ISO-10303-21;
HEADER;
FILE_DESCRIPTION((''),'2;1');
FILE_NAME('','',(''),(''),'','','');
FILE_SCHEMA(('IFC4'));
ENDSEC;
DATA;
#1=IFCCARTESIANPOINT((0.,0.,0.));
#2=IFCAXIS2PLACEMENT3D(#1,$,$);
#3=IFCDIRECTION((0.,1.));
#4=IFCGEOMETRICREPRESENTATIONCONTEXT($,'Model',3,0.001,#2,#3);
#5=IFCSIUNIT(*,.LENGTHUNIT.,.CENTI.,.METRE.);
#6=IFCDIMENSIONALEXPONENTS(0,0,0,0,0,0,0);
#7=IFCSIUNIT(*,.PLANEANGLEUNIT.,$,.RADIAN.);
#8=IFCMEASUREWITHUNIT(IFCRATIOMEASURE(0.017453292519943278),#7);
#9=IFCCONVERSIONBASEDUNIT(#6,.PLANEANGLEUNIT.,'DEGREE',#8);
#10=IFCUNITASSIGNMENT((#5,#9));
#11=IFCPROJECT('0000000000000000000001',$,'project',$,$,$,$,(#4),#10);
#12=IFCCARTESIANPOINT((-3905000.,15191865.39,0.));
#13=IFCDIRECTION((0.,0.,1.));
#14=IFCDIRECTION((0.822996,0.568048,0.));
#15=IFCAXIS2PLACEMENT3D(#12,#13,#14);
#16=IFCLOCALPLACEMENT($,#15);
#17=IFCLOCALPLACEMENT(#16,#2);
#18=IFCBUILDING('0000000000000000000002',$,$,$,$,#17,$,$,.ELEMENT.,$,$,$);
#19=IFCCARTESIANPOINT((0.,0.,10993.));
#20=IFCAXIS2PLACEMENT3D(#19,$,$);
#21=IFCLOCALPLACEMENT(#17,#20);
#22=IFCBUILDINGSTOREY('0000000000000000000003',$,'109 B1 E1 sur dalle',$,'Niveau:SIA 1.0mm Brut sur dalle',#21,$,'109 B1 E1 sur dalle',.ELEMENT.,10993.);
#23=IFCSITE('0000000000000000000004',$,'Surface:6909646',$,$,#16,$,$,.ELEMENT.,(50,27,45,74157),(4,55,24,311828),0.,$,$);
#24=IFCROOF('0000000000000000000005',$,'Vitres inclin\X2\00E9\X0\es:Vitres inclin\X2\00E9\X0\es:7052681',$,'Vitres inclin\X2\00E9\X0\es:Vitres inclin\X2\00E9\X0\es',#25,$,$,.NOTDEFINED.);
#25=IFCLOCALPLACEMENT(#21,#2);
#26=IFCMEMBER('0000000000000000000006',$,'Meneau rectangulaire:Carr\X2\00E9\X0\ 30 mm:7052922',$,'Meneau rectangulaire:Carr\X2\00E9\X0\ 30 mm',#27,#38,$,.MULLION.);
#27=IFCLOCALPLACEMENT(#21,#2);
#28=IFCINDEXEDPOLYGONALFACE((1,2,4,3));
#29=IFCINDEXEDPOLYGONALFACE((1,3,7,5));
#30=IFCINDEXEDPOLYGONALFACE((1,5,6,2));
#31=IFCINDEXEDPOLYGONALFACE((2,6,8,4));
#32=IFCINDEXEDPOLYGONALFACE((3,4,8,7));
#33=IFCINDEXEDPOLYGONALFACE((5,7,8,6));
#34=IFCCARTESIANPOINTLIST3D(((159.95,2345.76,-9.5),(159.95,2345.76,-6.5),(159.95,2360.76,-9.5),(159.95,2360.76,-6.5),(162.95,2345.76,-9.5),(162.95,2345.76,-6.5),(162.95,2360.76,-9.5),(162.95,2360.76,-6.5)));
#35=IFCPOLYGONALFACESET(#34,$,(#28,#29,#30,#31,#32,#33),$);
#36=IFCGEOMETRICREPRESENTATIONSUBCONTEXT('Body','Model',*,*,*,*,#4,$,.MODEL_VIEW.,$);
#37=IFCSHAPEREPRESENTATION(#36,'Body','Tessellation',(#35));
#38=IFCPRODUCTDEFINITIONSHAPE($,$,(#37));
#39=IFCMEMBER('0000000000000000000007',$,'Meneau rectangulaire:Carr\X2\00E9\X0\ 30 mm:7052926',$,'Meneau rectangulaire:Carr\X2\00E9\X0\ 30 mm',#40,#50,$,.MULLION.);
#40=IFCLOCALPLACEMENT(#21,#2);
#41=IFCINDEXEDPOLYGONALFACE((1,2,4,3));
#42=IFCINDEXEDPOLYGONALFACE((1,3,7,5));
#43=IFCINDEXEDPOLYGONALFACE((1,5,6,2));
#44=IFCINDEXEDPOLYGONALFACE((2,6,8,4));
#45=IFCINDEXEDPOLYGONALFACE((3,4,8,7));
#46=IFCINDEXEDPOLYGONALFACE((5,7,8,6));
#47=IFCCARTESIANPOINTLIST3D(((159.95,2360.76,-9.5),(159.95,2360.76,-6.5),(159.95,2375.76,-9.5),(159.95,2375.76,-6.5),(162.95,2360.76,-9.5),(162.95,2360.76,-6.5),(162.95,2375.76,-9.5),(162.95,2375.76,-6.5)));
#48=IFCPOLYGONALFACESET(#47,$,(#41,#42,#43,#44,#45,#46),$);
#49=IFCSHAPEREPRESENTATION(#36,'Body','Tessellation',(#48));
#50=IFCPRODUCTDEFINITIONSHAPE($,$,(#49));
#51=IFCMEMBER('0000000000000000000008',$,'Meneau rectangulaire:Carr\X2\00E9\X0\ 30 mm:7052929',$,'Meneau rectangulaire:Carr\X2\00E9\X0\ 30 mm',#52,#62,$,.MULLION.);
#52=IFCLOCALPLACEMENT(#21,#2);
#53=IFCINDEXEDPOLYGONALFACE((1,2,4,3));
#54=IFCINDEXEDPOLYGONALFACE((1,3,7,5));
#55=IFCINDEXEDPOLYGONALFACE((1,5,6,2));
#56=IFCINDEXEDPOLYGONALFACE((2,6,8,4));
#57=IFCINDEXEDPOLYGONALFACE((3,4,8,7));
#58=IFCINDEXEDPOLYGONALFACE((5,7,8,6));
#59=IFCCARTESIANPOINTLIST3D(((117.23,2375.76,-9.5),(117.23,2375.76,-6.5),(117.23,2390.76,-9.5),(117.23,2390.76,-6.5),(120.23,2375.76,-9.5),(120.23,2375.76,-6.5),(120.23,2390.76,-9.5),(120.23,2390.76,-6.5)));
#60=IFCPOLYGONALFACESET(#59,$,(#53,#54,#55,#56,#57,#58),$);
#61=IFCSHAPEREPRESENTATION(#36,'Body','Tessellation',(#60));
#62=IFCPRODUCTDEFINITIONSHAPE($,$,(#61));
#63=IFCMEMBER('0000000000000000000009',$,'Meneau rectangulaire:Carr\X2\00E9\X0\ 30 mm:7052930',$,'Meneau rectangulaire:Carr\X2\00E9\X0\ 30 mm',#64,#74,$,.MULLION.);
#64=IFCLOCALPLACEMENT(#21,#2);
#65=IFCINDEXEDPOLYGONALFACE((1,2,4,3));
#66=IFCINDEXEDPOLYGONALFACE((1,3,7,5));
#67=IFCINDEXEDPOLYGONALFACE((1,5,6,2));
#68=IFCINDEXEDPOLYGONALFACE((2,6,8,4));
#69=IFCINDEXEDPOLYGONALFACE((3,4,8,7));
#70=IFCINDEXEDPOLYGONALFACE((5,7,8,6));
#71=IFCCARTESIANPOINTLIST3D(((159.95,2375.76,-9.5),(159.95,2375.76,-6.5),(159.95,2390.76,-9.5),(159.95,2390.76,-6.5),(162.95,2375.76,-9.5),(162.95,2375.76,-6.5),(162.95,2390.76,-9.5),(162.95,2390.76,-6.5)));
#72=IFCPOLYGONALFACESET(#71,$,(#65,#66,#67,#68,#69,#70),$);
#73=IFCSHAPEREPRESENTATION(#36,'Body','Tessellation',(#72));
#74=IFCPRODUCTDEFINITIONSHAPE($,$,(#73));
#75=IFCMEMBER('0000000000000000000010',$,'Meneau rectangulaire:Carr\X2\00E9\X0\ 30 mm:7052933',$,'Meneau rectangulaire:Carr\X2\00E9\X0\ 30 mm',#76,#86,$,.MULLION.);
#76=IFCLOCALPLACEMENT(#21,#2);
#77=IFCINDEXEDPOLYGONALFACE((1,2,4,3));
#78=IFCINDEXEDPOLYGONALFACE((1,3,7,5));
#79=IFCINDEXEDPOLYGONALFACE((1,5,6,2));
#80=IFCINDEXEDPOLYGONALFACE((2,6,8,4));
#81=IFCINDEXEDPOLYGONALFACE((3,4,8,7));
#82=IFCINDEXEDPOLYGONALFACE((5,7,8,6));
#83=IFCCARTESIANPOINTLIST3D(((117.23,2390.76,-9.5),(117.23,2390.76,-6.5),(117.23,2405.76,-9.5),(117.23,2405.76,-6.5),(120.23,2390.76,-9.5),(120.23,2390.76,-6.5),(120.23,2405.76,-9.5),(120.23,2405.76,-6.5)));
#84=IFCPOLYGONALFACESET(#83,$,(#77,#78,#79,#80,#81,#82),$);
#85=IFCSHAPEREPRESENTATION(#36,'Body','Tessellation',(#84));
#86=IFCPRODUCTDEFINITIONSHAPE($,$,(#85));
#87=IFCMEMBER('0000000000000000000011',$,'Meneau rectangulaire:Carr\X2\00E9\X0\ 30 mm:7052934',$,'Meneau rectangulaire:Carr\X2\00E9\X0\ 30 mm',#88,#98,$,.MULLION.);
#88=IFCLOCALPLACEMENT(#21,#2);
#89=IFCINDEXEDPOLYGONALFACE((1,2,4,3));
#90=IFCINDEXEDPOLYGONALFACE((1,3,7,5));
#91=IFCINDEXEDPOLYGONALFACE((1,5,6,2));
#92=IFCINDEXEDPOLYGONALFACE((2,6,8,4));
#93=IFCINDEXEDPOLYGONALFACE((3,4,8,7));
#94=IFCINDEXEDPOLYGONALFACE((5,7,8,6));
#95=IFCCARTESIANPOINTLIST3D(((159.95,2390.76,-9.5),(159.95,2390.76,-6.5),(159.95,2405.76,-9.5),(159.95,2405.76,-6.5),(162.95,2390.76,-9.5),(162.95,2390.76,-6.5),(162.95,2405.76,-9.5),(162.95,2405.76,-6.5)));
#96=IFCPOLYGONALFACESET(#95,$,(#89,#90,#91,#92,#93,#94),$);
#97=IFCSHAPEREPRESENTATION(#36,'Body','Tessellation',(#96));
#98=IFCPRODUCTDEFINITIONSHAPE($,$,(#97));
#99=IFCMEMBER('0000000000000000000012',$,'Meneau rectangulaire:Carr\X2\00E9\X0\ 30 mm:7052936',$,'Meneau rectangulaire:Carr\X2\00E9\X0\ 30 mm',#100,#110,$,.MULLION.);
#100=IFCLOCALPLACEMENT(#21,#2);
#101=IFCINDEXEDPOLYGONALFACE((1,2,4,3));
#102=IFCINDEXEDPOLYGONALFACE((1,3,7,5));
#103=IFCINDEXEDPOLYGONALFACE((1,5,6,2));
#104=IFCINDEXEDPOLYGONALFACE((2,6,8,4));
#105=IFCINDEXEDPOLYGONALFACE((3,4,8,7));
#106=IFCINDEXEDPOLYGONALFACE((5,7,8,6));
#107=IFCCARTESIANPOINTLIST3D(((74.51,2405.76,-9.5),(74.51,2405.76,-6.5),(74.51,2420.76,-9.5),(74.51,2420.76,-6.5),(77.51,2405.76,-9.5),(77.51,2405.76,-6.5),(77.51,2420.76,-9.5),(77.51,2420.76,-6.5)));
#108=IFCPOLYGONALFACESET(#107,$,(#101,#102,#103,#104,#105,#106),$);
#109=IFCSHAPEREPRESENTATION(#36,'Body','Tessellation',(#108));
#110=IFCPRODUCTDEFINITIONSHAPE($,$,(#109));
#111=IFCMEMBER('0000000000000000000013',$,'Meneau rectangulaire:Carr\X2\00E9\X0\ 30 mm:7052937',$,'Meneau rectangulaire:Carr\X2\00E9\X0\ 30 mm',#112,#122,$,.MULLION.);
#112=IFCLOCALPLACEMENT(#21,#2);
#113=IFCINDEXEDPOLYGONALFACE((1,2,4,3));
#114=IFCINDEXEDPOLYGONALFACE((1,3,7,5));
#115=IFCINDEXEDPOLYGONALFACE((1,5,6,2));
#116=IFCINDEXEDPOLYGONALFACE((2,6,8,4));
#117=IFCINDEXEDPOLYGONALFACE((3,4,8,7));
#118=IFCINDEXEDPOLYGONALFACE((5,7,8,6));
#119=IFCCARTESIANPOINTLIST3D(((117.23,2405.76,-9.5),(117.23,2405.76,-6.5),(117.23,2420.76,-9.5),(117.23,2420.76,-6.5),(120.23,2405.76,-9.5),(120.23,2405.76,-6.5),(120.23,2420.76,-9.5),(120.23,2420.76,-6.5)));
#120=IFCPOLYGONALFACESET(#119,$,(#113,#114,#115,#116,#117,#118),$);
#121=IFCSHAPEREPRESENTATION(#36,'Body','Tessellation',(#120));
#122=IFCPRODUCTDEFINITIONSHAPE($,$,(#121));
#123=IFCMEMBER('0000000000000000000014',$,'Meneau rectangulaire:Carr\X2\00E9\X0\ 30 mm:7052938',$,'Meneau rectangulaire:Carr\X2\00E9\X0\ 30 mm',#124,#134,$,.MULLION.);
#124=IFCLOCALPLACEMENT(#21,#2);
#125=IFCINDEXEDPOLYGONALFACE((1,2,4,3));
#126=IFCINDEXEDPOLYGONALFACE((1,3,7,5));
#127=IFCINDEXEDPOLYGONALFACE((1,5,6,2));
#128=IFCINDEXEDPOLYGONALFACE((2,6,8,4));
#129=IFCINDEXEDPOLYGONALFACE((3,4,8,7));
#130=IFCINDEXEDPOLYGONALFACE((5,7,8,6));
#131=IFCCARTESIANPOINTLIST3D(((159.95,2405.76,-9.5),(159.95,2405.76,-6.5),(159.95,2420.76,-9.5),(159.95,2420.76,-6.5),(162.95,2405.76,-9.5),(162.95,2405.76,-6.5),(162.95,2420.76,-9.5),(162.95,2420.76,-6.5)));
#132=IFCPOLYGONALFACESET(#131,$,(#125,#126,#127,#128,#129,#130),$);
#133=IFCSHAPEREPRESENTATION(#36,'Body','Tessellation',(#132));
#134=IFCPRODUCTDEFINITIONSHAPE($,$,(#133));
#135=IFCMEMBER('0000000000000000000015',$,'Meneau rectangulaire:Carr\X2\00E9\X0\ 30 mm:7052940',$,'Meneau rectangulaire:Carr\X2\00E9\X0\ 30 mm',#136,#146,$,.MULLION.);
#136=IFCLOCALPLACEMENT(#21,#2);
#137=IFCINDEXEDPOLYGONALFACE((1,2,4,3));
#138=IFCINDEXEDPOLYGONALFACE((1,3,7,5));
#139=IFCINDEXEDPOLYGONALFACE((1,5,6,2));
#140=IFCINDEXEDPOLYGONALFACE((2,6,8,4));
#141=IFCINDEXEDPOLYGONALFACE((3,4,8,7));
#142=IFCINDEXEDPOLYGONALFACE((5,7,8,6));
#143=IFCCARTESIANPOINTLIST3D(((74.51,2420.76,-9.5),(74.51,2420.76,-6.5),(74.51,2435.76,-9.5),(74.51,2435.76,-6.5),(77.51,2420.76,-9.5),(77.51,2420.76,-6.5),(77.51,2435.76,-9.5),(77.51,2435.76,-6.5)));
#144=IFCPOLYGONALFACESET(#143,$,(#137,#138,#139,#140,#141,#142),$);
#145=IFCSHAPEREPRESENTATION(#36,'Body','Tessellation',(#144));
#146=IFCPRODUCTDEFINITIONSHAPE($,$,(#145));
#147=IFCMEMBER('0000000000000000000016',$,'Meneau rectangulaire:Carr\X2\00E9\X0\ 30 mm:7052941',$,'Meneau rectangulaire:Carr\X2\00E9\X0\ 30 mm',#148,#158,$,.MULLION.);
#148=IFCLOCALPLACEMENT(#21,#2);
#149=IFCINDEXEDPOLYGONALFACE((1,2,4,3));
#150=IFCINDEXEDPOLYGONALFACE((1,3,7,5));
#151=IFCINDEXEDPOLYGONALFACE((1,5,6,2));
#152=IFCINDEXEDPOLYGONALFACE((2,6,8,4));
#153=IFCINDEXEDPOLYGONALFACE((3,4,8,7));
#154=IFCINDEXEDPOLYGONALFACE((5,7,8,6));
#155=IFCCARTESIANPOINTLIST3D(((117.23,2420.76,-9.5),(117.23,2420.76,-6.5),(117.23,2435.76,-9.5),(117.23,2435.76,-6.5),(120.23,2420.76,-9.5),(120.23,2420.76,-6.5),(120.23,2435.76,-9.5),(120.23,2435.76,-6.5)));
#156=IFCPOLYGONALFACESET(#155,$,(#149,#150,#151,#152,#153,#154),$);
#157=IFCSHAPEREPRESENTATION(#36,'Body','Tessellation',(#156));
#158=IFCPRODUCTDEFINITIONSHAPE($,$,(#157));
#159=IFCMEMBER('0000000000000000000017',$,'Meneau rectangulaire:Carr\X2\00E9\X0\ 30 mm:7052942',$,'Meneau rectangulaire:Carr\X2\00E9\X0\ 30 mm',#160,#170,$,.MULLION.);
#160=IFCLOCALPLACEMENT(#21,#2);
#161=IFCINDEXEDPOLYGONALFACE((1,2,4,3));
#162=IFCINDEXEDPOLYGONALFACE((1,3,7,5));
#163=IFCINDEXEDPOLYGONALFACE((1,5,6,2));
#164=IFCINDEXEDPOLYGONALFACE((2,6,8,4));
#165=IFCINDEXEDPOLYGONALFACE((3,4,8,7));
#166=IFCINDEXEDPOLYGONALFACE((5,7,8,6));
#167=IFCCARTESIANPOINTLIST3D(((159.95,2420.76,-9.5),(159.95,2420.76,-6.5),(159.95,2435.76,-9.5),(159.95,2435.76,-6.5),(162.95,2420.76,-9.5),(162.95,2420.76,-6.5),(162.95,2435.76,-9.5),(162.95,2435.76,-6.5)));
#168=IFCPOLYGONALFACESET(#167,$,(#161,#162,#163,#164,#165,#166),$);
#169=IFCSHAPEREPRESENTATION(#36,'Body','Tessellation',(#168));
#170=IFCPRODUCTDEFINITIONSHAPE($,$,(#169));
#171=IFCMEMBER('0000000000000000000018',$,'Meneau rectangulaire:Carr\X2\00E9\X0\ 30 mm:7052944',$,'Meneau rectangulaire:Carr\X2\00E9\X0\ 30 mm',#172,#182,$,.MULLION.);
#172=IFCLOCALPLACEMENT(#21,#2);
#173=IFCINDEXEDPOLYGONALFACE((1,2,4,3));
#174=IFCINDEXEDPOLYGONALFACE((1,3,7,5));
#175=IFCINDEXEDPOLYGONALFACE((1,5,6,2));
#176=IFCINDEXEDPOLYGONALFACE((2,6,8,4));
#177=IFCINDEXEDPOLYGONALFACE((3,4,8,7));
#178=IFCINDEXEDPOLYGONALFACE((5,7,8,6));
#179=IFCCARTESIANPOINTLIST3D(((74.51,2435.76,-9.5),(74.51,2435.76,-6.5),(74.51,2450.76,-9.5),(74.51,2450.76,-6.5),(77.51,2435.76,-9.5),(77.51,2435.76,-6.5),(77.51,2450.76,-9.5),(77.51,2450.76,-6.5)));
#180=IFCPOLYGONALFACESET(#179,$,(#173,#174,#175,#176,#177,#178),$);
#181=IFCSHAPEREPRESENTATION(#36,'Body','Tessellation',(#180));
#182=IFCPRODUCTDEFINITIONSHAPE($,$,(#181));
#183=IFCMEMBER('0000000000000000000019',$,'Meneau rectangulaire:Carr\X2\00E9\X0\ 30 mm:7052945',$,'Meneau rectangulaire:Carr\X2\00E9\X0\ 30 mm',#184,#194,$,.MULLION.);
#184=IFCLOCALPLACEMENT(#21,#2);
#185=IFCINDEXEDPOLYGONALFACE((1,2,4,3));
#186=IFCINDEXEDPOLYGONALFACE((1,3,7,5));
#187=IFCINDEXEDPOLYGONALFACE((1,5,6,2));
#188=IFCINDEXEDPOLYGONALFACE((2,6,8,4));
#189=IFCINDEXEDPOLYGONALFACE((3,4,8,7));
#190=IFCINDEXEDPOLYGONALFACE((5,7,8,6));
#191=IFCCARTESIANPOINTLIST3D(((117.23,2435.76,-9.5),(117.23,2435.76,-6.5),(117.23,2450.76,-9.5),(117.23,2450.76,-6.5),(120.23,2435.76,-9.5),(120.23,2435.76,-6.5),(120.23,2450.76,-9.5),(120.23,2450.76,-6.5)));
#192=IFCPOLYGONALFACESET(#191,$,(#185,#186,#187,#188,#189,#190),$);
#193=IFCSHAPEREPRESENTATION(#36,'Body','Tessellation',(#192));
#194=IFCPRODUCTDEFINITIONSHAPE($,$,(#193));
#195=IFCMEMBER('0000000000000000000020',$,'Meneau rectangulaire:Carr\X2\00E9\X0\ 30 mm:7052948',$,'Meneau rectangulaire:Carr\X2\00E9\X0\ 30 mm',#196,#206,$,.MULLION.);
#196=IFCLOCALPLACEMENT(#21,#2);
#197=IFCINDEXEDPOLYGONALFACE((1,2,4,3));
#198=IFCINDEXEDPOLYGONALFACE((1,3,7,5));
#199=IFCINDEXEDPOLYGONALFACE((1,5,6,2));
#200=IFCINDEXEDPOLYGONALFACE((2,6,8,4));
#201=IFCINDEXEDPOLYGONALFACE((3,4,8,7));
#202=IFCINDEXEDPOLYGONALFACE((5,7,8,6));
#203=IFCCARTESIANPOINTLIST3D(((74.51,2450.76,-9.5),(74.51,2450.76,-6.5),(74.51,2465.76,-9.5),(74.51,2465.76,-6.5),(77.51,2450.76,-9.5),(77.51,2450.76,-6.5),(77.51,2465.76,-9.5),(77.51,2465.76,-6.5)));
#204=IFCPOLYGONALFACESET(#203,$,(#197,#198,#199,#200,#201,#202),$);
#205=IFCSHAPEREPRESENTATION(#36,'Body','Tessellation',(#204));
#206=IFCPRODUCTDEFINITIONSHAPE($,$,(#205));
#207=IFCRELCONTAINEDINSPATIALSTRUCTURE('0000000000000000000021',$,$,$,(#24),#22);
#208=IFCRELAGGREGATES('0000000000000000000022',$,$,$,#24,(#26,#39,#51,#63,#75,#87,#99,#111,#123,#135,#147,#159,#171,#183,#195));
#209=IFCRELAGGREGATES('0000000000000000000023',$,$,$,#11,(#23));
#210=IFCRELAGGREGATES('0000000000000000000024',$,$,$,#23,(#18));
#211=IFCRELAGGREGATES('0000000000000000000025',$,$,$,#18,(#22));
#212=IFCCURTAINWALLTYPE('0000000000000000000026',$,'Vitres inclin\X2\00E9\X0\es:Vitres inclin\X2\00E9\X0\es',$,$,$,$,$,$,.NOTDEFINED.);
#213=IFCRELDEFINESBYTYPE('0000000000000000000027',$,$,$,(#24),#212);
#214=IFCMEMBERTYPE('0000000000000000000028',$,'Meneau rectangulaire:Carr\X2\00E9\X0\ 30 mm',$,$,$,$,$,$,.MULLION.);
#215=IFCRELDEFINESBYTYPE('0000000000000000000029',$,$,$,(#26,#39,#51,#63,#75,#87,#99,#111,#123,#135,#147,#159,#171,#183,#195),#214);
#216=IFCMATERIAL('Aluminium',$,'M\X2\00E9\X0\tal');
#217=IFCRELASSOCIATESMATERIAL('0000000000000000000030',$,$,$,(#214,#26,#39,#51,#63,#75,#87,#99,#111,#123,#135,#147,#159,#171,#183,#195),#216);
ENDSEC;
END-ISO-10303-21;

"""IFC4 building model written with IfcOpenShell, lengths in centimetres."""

from ifc_helpers import new_model, entity, si_unit, converted_unit, direction, frame, origin, place, context, subcontext, project, spatial, indexed_curve, outline, extrude, source, transform, mapped, material, type_object, type_shapes, element, aggregate, save


model = new_model("IFC4")

# Units and contexts
model_context = context("Model", 3, precision=0.001, world=origin(), true_north=direction((0.0, 1.0)))
body_context = subcontext(model_context, "Body", "Model", "MODEL_VIEW")
ifc_project = project(units=[si_unit("LENGTHUNIT", "METRE", prefix="CENTI"), converted_unit("PLANEANGLEUNIT", "DEGREE", entity("IfcRatioMeasure", 0.017453292519943278), si_unit("PLANEANGLEUNIT", "RADIAN"), dimensions=[0, 0, 0, 0, 0, 0, 0])], contexts=[model_context])

# Site, building, storey
site_placement = place(None, frame((-3905000.0, 15191865.39, 0.0), z_axis=(0.0, 0.0, 1.0), x_axis=(0.822996, 0.568048, 0.0)))
site = spatial("IfcSite", under=ifc_project, at=site_placement, Name="Surface:6909646", CompositionType="ELEMENT", RefLatitude=(50, 27, 45, 74157), RefLongitude=(4, 55, 24, 311828), RefElevation=0.0)
building_placement = place(site_placement, origin())
building = spatial("IfcBuilding", under=site, at=building_placement, CompositionType="ELEMENT")
storey_placement = place(building_placement, frame((0.0, 0.0, 10993.0)))
storey = spatial("IfcBuildingStorey", under=building, at=storey_placement, Name="109 B1 E1 sur dalle", ObjectType="Niveau:SIA 1.0mm Brut sur dalle", LongName="109 B1 E1 sur dalle", CompositionType="ELEMENT", Elevation=10993.0)

# Roof, members
curtain_wall_type = type_object("IfcCurtainWallType", Name="Vitres inclinées:Vitres inclinées", PredefinedType="NOTDEFINED")
roof_placement = place(storey_placement, frame((0.0, 0.0, -10993.0)))
roof = element("IfcRoof", 1, at=roof_placement, inside=storey, type_object=curtain_wall_type, Name="Vitres inclinées:Vitres inclinées:7052681", ObjectType="Vitres inclinées:Vitres inclinées", PredefinedType="NOTDEFINED")
ifc_material = material(Name="Aluminium", Category="Métal")
member_type_1 = type_object("IfcMemberType", Name="Meneau rectangulaire:Carré 30 mm", PredefinedType="MULLION", material=ifc_material)
shared_shape_1 = source(origin(), body_context, "Body", "SweptSolid", [
    extrude(outline(indexed_curve([(-1.5, -1.5), (1.5, -1.5), (1.5, 1.5), (-1.5, 1.5), (-1.5, -1.5)], self_intersect=False)), frame((0.0, 0.0, -15.0), z_axis=(0.0, 0.0, 1.0), x_axis=(0.0, -1.0, 0.0)), (0.0, 0.0, 1.0), 15.0),
])
type_shapes(member_type_1, [shared_shape_1])
member_1_placement = place(roof_placement, frame((161.45, 2360.76, 10985.0), z_axis=(0.0, 1.0, 0.0), x_axis=(1.0, 0.0, 0.0)))
member_1 = element("IfcMember", 2, at=member_1_placement, type_object=member_type_1, material=ifc_material, Name="Meneau rectangulaire:Carré 30 mm:7052922", ObjectType="Meneau rectangulaire:Carré 30 mm", PredefinedType="MULLION", context=body_context, shape_type="MappedRepresentation", body=[
    mapped(shared_shape_1, transform((0.0, 0.0, 0.0), scale=1.0)),
])
member_2_placement = place(roof_placement, frame((161.45, 2375.76, 10985.0), z_axis=(0.0, 1.0, 0.0), x_axis=(1.0, 0.0, 0.0)))
member_2 = element("IfcMember", 3, at=member_2_placement, type_object=member_type_1, material=ifc_material, Name="Meneau rectangulaire:Carré 30 mm:7052926", ObjectType="Meneau rectangulaire:Carré 30 mm", PredefinedType="MULLION", context=body_context, shape_type="MappedRepresentation", body=[
    mapped(shared_shape_1, transform((0.0, 0.0, 0.0), scale=1.0)),
])
member_3_placement = place(roof_placement, frame((118.73, 2390.76, 10985.0), z_axis=(0.0, 1.0, 0.0), x_axis=(1.0, 0.0, 0.0)))
member_3 = element("IfcMember", 4, at=member_3_placement, type_object=member_type_1, material=ifc_material, Name="Meneau rectangulaire:Carré 30 mm:7052929", ObjectType="Meneau rectangulaire:Carré 30 mm", PredefinedType="MULLION", context=body_context, shape_type="MappedRepresentation", body=[
    mapped(shared_shape_1, transform((0.0, 0.0, 0.0), scale=1.0)),
])
member_4_placement = place(roof_placement, frame((161.45, 2390.76, 10985.0), z_axis=(0.0, 1.0, 0.0), x_axis=(1.0, 0.0, 0.0)))
member_4 = element("IfcMember", 5, at=member_4_placement, type_object=member_type_1, material=ifc_material, Name="Meneau rectangulaire:Carré 30 mm:7052930", ObjectType="Meneau rectangulaire:Carré 30 mm", PredefinedType="MULLION", context=body_context, shape_type="MappedRepresentation", body=[
    mapped(shared_shape_1, transform((0.0, 0.0, 0.0), scale=1.0)),
])
member_5_placement = place(roof_placement, frame((118.73, 2405.76, 10985.0), z_axis=(0.0, 1.0, 0.0), x_axis=(1.0, 0.0, 0.0)))
member_5 = element("IfcMember", 6, at=member_5_placement, type_object=member_type_1, material=ifc_material, Name="Meneau rectangulaire:Carré 30 mm:7052933", ObjectType="Meneau rectangulaire:Carré 30 mm", PredefinedType="MULLION", context=body_context, shape_type="MappedRepresentation", body=[
    mapped(shared_shape_1, transform((0.0, 0.0, 0.0), scale=1.0)),
])
member_6_placement = place(roof_placement, frame((161.45, 2405.76, 10985.0), z_axis=(0.0, 1.0, 0.0), x_axis=(1.0, 0.0, 0.0)))
member_6 = element("IfcMember", 7, at=member_6_placement, type_object=member_type_1, material=ifc_material, Name="Meneau rectangulaire:Carré 30 mm:7052934", ObjectType="Meneau rectangulaire:Carré 30 mm", PredefinedType="MULLION", context=body_context, shape_type="MappedRepresentation", body=[
    mapped(shared_shape_1, transform((0.0, 0.0, 0.0), scale=1.0)),
])
member_7_placement = place(roof_placement, frame((76.01, 2420.76, 10985.0), z_axis=(0.0, 1.0, 0.0), x_axis=(1.0, 0.0, 0.0)))
member_7 = element("IfcMember", 8, at=member_7_placement, type_object=member_type_1, material=ifc_material, Name="Meneau rectangulaire:Carré 30 mm:7052936", ObjectType="Meneau rectangulaire:Carré 30 mm", PredefinedType="MULLION", context=body_context, shape_type="MappedRepresentation", body=[
    mapped(shared_shape_1, transform((0.0, 0.0, 0.0), scale=1.0)),
])
member_8_placement = place(roof_placement, frame((118.73, 2420.76, 10985.0), z_axis=(0.0, 1.0, 0.0), x_axis=(1.0, 0.0, 0.0)))
member_8 = element("IfcMember", 9, at=member_8_placement, type_object=member_type_1, material=ifc_material, Name="Meneau rectangulaire:Carré 30 mm:7052937", ObjectType="Meneau rectangulaire:Carré 30 mm", PredefinedType="MULLION", context=body_context, shape_type="MappedRepresentation", body=[
    mapped(shared_shape_1, transform((0.0, 0.0, 0.0), scale=1.0)),
])
member_9_placement = place(roof_placement, frame((161.45, 2420.76, 10985.0), z_axis=(0.0, 1.0, 0.0), x_axis=(1.0, 0.0, 0.0)))
member_9 = element("IfcMember", 10, at=member_9_placement, type_object=member_type_1, material=ifc_material, Name="Meneau rectangulaire:Carré 30 mm:7052938", ObjectType="Meneau rectangulaire:Carré 30 mm", PredefinedType="MULLION", context=body_context, shape_type="MappedRepresentation", body=[
    mapped(shared_shape_1, transform((0.0, 0.0, 0.0), scale=1.0)),
])
member_10_placement = place(roof_placement, frame((76.01, 2435.76, 10985.0), z_axis=(0.0, 1.0, 0.0), x_axis=(1.0, 0.0, 0.0)))
member_10 = element("IfcMember", 11, at=member_10_placement, type_object=member_type_1, material=ifc_material, Name="Meneau rectangulaire:Carré 30 mm:7052940", ObjectType="Meneau rectangulaire:Carré 30 mm", PredefinedType="MULLION", context=body_context, shape_type="MappedRepresentation", body=[
    mapped(shared_shape_1, transform((0.0, 0.0, 0.0), scale=1.0)),
])
member_11_placement = place(roof_placement, frame((118.73, 2435.76, 10985.0), z_axis=(0.0, 1.0, 0.0), x_axis=(1.0, 0.0, 0.0)))
member_11 = element("IfcMember", 12, at=member_11_placement, type_object=member_type_1, material=ifc_material, Name="Meneau rectangulaire:Carré 30 mm:7052941", ObjectType="Meneau rectangulaire:Carré 30 mm", PredefinedType="MULLION", context=body_context, shape_type="MappedRepresentation", body=[
    mapped(shared_shape_1, transform((0.0, 0.0, 0.0), scale=1.0)),
])
member_12_placement = place(roof_placement, frame((161.45, 2435.76, 10985.0), z_axis=(0.0, 1.0, 0.0), x_axis=(1.0, 0.0, 0.0)))
member_12 = element("IfcMember", 13, at=member_12_placement, type_object=member_type_1, material=ifc_material, Name="Meneau rectangulaire:Carré 30 mm:7052942", ObjectType="Meneau rectangulaire:Carré 30 mm", PredefinedType="MULLION", context=body_context, shape_type="MappedRepresentation", body=[
    mapped(shared_shape_1, transform((0.0, 0.0, 0.0), scale=1.0)),
])
member_13_placement = place(roof_placement, frame((76.01, 2450.76, 10985.0), z_axis=(0.0, 1.0, 0.0), x_axis=(1.0, 0.0, 0.0)))
member_13 = element("IfcMember", 14, at=member_13_placement, type_object=member_type_1, material=ifc_material, Name="Meneau rectangulaire:Carré 30 mm:7052944", ObjectType="Meneau rectangulaire:Carré 30 mm", PredefinedType="MULLION", context=body_context, shape_type="MappedRepresentation", body=[
    mapped(shared_shape_1, transform((0.0, 0.0, 0.0), scale=1.0)),
])
member_14_placement = place(roof_placement, frame((118.73, 2450.76, 10985.0), z_axis=(0.0, 1.0, 0.0), x_axis=(1.0, 0.0, 0.0)))
member_14 = element("IfcMember", 15, at=member_14_placement, type_object=member_type_1, material=ifc_material, Name="Meneau rectangulaire:Carré 30 mm:7052945", ObjectType="Meneau rectangulaire:Carré 30 mm", PredefinedType="MULLION", context=body_context, shape_type="MappedRepresentation", body=[
    mapped(shared_shape_1, transform((0.0, 0.0, 0.0), scale=1.0)),
])
member_15_placement = place(roof_placement, frame((76.01, 2465.76, 10985.0), z_axis=(0.0, 1.0, 0.0), x_axis=(1.0, 0.0, 0.0)))
member_15 = element("IfcMember", 16, at=member_15_placement, type_object=member_type_1, material=ifc_material, Name="Meneau rectangulaire:Carré 30 mm:7052948", ObjectType="Meneau rectangulaire:Carré 30 mm", PredefinedType="MULLION", context=body_context, shape_type="MappedRepresentation", body=[
    mapped(shared_shape_1, transform((0.0, 0.0, 0.0), scale=1.0)),
])
aggregate(roof, [member_1, member_2, member_3, member_4, member_5, member_6, member_7, member_8, member_9, member_10, member_11, member_12, member_13, member_14, member_15])

save(model, "model.ifc")
